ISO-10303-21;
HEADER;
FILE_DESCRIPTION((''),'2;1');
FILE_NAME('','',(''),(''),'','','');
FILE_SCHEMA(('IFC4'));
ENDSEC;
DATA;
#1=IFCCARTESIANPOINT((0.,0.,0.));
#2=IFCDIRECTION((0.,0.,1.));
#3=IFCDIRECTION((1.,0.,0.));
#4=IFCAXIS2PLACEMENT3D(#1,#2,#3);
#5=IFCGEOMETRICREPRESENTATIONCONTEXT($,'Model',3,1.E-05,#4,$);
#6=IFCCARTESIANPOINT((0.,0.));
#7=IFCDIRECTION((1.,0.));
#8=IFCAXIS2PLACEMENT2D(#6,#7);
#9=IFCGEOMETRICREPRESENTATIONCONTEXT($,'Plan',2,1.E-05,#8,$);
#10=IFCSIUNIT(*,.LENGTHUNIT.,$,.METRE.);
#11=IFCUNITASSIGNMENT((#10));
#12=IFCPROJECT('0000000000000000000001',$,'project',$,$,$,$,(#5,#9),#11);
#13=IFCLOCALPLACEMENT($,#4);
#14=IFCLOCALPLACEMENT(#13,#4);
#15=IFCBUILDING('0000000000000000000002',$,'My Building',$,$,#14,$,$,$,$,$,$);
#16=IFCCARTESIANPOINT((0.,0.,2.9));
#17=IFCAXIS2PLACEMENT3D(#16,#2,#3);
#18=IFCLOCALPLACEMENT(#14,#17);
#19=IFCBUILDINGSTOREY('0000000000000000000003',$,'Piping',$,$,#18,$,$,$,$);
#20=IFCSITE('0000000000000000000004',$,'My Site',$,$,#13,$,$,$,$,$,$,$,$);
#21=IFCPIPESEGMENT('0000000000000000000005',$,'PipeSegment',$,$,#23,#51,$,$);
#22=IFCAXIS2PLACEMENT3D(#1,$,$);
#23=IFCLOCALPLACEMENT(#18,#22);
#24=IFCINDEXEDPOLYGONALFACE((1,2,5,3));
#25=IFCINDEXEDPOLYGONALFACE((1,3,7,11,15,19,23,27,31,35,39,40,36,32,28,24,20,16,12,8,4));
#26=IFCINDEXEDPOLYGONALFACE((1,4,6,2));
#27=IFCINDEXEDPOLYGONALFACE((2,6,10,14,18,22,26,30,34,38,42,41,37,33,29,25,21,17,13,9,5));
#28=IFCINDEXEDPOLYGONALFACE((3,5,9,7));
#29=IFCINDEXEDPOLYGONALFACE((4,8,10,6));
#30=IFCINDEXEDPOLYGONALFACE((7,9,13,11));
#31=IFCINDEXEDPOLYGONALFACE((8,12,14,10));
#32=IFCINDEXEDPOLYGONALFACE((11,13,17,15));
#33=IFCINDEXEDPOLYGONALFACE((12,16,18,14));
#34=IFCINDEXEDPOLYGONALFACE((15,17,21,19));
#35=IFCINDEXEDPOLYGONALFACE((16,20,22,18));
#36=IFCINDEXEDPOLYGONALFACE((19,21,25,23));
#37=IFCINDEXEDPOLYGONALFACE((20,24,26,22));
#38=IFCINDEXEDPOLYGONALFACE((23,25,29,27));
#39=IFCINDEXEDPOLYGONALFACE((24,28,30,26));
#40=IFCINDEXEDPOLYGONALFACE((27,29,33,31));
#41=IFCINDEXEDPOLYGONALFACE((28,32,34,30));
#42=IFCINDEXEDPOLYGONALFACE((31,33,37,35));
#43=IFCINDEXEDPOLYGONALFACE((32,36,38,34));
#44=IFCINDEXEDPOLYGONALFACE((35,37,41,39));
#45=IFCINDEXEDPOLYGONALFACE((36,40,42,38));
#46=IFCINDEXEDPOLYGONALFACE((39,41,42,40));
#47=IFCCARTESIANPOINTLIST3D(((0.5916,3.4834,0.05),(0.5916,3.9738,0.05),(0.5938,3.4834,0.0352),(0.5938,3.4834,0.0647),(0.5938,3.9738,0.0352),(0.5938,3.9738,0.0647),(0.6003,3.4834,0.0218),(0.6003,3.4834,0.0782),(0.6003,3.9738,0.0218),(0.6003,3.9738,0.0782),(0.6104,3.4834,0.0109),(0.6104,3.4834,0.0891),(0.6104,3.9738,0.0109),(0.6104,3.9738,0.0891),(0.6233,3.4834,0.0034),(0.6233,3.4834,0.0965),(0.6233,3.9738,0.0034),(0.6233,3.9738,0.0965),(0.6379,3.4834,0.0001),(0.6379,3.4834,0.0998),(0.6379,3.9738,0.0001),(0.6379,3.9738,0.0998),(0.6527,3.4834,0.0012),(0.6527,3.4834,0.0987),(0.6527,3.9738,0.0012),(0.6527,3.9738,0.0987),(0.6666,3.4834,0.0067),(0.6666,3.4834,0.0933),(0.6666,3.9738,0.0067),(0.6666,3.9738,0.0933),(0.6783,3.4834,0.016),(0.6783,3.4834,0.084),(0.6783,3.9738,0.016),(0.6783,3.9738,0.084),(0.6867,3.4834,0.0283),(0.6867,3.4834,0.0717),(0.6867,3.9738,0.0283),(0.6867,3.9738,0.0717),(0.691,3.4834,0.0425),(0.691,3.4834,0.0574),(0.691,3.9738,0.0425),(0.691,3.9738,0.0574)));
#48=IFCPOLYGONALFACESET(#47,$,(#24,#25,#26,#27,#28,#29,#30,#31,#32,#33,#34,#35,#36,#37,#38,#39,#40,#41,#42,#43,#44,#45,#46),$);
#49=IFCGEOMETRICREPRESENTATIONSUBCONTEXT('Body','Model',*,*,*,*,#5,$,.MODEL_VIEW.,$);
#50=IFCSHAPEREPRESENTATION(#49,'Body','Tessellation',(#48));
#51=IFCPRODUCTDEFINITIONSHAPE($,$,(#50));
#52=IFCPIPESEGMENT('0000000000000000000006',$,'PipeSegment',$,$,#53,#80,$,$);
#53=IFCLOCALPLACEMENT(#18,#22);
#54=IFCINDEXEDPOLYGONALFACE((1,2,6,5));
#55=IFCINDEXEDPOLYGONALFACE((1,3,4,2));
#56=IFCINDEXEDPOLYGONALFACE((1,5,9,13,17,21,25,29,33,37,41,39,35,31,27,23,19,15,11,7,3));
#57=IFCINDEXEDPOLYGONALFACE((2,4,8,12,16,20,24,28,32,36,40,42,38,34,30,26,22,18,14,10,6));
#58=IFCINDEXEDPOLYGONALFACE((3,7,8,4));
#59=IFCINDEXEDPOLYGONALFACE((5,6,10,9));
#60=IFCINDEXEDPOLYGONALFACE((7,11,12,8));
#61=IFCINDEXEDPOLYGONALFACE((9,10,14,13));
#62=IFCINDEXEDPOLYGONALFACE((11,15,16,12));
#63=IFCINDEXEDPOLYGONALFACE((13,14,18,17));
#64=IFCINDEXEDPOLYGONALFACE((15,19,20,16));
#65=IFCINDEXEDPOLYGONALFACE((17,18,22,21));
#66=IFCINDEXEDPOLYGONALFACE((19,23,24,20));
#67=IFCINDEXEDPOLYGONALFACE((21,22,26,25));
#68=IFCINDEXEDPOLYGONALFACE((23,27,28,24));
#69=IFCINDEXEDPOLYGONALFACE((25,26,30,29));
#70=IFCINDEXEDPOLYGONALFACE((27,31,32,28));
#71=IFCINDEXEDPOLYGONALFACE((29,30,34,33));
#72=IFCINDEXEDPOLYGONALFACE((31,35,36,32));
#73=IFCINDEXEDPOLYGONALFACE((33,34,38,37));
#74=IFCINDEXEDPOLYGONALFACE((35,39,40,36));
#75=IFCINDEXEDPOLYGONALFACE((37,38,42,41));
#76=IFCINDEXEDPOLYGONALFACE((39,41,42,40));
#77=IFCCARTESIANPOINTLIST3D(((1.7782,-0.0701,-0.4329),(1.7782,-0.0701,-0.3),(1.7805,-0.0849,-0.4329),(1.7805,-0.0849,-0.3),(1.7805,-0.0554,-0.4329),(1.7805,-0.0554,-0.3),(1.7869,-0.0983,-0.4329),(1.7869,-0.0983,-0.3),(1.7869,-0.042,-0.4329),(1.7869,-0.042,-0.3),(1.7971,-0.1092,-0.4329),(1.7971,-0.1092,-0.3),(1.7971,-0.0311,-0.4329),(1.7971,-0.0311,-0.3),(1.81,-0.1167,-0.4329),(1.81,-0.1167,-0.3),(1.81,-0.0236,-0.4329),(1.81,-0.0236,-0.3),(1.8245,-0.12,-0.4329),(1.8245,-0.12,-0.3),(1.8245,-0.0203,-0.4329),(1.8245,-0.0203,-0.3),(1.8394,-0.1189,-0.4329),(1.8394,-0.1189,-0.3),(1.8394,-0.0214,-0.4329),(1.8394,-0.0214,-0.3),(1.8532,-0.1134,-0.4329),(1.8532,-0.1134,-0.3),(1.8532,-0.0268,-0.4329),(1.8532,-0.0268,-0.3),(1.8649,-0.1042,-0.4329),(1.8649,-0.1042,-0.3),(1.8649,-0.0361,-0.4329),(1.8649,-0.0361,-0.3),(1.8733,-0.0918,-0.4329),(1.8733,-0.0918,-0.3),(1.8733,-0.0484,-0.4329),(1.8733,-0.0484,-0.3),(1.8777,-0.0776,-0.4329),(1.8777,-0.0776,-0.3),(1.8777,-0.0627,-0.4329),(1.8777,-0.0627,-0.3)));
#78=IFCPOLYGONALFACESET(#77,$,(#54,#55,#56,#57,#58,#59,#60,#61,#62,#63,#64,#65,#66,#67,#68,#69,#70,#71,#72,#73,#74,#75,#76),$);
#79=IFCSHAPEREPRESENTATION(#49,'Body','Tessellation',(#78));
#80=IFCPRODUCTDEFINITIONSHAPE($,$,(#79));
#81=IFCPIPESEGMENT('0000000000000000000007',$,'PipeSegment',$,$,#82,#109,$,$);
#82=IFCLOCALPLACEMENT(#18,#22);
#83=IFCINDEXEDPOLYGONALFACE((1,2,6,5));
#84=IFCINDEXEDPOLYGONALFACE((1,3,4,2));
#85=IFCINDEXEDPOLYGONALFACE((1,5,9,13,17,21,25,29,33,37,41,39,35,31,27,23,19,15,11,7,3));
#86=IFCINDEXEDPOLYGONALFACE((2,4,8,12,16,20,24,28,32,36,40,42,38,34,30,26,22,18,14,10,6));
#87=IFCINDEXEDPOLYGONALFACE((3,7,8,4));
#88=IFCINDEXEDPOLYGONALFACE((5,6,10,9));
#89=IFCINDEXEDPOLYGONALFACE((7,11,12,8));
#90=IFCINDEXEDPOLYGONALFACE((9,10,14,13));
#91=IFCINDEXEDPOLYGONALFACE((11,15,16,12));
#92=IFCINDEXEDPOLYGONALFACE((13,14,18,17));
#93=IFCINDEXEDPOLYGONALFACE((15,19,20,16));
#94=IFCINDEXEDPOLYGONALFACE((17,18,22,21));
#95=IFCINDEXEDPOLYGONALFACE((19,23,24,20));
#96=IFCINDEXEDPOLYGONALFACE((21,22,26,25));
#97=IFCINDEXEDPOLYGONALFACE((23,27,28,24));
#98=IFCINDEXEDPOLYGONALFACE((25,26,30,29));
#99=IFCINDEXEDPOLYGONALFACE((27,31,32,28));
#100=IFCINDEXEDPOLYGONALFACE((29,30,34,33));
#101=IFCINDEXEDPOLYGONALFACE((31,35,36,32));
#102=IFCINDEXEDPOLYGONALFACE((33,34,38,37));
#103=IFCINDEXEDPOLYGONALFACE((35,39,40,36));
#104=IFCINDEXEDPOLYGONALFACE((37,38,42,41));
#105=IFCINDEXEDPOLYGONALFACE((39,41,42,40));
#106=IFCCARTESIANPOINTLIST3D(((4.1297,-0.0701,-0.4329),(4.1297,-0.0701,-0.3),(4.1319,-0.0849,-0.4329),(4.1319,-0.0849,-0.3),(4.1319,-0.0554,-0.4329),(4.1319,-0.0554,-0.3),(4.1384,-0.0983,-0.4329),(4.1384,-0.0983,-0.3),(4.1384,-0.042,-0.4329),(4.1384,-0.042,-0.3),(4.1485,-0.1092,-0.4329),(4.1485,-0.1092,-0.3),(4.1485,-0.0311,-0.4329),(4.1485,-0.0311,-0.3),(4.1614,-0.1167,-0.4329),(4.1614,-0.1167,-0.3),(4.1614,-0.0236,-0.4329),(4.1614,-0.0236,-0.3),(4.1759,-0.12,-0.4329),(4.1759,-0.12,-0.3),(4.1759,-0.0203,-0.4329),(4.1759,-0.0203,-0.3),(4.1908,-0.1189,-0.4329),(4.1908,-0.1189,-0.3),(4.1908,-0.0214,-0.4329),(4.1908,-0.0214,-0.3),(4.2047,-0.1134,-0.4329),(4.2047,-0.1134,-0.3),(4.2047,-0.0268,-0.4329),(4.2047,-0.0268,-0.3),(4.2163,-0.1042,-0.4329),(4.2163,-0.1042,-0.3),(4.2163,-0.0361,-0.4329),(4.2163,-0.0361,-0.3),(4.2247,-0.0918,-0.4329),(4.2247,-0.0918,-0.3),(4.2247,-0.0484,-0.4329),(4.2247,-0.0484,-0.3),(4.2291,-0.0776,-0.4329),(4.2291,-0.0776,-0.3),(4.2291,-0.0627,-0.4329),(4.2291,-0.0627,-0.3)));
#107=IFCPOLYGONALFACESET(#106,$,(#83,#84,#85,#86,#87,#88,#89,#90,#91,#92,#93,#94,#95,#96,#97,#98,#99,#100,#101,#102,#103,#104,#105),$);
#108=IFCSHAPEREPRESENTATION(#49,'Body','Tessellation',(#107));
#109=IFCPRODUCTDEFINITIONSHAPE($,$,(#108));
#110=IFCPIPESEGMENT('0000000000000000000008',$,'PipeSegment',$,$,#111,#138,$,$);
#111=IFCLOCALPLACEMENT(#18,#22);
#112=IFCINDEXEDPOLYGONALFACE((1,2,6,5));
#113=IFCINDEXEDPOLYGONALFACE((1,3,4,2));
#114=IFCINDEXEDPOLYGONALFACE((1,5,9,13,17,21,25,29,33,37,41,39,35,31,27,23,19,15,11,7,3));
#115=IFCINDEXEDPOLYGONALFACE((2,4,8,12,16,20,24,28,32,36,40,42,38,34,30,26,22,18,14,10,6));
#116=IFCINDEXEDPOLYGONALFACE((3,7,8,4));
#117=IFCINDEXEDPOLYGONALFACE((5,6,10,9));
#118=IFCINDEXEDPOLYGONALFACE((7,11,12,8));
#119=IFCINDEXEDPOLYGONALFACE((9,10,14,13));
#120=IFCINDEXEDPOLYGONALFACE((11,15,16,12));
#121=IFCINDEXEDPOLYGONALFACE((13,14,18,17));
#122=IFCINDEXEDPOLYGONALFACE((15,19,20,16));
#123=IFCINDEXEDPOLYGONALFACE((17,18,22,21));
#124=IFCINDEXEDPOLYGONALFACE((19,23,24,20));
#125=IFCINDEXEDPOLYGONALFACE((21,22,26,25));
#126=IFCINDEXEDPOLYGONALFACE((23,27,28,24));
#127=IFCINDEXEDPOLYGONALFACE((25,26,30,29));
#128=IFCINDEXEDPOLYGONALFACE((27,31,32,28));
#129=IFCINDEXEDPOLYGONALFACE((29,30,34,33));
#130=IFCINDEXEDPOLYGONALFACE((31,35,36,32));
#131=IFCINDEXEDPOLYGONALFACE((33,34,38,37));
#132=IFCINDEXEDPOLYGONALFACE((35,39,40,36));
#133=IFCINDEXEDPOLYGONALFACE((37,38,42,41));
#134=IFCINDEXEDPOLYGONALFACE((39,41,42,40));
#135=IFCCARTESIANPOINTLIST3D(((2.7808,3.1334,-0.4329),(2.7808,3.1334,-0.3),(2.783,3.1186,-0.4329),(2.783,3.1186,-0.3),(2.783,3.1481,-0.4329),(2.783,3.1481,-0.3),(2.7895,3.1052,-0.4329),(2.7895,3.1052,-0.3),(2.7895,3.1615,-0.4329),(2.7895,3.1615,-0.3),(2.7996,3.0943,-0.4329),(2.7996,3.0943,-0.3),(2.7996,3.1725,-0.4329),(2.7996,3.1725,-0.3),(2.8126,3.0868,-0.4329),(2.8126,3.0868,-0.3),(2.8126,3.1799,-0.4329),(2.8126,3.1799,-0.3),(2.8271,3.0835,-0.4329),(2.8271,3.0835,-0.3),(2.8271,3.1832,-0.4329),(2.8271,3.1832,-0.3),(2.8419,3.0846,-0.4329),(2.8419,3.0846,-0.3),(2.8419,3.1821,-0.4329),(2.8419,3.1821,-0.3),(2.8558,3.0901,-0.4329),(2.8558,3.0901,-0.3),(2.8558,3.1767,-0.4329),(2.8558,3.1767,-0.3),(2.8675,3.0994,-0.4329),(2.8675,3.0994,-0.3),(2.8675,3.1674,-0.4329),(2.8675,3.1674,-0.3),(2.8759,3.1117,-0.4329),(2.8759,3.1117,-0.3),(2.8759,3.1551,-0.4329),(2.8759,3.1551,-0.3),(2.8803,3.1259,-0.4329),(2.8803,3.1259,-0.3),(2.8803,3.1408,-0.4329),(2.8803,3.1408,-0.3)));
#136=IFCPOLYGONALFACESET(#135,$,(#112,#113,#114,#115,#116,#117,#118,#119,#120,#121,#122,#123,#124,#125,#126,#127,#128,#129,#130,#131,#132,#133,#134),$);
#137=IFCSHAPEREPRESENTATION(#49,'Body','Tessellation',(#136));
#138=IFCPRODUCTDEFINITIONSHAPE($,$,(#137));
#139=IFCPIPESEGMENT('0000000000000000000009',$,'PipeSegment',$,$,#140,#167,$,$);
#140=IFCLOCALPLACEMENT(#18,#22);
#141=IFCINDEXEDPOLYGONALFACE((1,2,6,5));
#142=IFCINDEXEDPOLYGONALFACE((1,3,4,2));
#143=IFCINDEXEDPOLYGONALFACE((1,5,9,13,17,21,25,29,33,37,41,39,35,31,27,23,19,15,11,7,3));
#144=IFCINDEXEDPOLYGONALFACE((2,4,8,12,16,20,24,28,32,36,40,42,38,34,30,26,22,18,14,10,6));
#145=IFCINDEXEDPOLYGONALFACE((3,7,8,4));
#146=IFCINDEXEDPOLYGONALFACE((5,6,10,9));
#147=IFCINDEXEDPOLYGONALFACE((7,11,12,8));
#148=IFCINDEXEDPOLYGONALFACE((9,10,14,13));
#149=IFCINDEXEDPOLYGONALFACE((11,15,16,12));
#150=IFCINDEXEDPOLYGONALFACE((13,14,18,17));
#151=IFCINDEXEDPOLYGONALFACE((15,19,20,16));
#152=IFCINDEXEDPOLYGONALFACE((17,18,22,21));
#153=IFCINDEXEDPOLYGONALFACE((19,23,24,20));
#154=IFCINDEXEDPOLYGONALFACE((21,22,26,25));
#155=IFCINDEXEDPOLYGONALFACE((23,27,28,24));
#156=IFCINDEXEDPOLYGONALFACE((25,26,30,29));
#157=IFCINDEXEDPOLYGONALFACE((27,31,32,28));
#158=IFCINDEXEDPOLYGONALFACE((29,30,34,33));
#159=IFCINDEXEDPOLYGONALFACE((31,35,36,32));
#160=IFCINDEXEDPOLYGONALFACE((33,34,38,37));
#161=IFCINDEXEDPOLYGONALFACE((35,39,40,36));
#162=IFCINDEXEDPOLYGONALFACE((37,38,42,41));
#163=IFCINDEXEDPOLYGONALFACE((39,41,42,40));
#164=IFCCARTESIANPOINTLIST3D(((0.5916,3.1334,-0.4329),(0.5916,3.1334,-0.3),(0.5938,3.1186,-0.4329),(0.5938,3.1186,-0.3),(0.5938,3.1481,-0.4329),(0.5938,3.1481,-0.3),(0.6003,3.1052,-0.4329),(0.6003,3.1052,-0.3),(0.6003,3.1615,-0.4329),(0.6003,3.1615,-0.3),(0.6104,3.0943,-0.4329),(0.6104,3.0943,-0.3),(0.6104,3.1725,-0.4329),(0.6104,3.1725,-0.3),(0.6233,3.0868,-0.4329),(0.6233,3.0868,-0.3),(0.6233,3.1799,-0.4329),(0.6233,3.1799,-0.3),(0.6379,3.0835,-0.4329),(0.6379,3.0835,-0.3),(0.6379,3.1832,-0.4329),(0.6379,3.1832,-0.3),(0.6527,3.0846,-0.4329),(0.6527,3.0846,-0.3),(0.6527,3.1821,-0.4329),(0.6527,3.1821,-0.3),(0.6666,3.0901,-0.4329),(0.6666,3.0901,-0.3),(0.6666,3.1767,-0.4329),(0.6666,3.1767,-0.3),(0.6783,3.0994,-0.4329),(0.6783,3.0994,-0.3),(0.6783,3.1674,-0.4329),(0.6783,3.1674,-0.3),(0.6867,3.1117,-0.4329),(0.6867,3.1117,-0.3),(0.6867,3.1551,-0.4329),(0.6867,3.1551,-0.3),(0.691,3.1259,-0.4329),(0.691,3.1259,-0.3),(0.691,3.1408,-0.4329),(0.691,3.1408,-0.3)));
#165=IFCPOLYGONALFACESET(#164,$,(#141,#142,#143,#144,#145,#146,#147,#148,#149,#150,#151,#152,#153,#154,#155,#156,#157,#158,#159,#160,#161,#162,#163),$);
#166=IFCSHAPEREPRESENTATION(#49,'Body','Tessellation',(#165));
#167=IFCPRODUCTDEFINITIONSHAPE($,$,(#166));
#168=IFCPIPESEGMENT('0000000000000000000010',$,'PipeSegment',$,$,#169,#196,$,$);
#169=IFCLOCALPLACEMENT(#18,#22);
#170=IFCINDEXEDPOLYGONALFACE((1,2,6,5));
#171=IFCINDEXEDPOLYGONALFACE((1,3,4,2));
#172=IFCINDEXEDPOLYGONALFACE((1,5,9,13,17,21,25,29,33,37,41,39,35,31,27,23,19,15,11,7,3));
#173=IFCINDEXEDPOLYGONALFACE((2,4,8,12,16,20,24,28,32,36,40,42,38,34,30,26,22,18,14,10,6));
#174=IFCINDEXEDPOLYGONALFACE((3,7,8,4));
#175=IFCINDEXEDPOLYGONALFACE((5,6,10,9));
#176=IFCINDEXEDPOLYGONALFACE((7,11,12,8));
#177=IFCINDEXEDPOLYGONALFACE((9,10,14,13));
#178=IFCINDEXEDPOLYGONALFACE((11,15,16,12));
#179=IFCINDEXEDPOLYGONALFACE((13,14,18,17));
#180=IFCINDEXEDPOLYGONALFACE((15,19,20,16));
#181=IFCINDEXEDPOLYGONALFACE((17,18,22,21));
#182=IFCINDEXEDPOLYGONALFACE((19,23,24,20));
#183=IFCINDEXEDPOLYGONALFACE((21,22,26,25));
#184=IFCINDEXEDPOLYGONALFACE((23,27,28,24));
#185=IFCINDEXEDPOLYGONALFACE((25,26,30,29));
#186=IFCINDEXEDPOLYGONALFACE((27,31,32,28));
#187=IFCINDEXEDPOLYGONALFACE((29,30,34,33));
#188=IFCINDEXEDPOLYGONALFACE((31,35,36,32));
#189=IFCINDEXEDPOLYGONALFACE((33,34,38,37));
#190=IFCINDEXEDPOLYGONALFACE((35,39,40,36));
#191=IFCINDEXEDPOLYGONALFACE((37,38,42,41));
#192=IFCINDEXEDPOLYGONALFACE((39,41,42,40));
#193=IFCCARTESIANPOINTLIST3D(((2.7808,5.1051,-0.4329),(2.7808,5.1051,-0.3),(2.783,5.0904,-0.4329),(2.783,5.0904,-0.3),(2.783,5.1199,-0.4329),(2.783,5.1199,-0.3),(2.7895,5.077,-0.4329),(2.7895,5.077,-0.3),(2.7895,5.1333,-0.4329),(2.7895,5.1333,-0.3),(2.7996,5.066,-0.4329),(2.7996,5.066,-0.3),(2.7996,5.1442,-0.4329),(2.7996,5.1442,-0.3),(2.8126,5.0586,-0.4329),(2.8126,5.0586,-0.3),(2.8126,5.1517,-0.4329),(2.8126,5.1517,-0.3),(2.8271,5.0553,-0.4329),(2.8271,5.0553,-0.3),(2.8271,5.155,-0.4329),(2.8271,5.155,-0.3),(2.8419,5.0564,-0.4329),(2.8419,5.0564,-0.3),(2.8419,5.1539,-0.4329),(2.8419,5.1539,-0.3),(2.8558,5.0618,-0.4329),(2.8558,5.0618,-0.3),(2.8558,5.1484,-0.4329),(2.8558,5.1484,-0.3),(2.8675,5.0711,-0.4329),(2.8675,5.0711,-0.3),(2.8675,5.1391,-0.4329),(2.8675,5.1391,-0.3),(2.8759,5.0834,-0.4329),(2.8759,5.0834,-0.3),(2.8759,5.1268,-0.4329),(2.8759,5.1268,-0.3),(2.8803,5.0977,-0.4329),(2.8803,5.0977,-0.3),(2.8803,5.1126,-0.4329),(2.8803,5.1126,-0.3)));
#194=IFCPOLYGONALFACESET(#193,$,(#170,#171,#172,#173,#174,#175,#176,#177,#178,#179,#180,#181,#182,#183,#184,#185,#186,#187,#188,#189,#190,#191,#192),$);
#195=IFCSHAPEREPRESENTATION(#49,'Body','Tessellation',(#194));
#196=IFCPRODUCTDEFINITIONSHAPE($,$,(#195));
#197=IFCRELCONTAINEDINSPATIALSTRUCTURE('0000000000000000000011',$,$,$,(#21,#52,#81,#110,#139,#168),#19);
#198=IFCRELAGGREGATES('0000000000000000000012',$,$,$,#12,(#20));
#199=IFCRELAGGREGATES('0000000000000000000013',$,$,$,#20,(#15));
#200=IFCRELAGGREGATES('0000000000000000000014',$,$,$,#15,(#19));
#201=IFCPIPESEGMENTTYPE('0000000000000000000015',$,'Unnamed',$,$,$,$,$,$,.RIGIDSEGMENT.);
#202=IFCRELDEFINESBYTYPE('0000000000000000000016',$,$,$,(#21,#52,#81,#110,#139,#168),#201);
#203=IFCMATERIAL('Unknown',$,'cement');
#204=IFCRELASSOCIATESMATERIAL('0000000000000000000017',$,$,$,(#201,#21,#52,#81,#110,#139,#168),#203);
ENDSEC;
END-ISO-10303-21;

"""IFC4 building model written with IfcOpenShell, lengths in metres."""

from ifc_helpers import new_model, si_unit, frame, origin_with_axes, origin_2d_with_axis, place, context, subcontext, project, spatial, circle, extrude, material, material_profile, profile_set, profile_usage, type_object, element, save


model = new_model("IFC4")

# Units and contexts
model_context = context("Model", 3, precision=1e-05, world=origin_with_axes())
plan_context = context("Plan", 2, precision=1e-05, world=origin_2d_with_axis())
body_context = subcontext(model_context, "Body", "Model", "MODEL_VIEW")
ifc_project = project(units=[si_unit("LENGTHUNIT", "METRE")], contexts=[model_context, plan_context])

# Site, building, storey
site_placement = place(None, origin_with_axes())
site = spatial("IfcSite", under=ifc_project, at=site_placement, Name="My Site")
building_placement = place(site_placement, origin_with_axes())
building = spatial("IfcBuilding", under=site, at=building_placement, Name="My Building")
storey_placement = place(building_placement, frame((0.0, 0.0, 2.9), z_axis=(0.0, 0.0, 1.0), x_axis=(1.0, 0.0, 0.0)))
storey = spatial("IfcBuildingStorey", under=building, at=storey_placement, Name="Piping")

# Pipe segments
ifc_material = material(Name="Unknown", Category="cement")
ifc_material_profile_1 = material_profile(ifc_material, circle(Radius=0.05))
ifc_profile_set_1 = profile_set([ifc_material_profile_1])
pipe_segment_type = type_object("IfcPipeSegmentType", Name="Unnamed", PredefinedType="RIGIDSEGMENT", material=ifc_profile_set_1)
ifc_profile_usage_1 = profile_usage(ifc_profile_set_1, cardinal=5)
pipe_segment_1_placement = place(storey_placement, frame((0.6416, 3.4834, 0.05), z_axis=(0.0, 1.0, 0.0), x_axis=(-1.0, 0.0, 0.0)))
element("IfcPipeSegment", 1, at=pipe_segment_1_placement, inside=storey, type_object=pipe_segment_type, material=ifc_profile_usage_1, Name="PipeSegment", context=body_context, shape_type="SweptSolid", body=[
    extrude(circle(Radius=0.05), origin_with_axes(), (0.0, 0.0, 1.0), 0.4905),
])
ifc_profile_usage_2 = profile_usage(ifc_profile_set_1, cardinal=5)
pipe_segment_2_placement = place(storey_placement, frame((1.8282, -0.0701, -0.4329), z_axis=(0.0, 0.0, 1.0), x_axis=(-1.0, 0.0, 0.0)))
element("IfcPipeSegment", 2, at=pipe_segment_2_placement, inside=storey, type_object=pipe_segment_type, material=ifc_profile_usage_2, Name="PipeSegment", context=body_context, shape_type="SweptSolid", body=[
    extrude(circle(Radius=0.05), origin_with_axes(), (0.0, 0.0, 1.0), 0.1329),
])
ifc_profile_usage_3 = profile_usage(ifc_profile_set_1, cardinal=5)
pipe_segment_3_placement = place(storey_placement, frame((4.1797, -0.0701, -0.4329), z_axis=(0.0, 0.0, 1.0), x_axis=(-1.0, 0.0, 0.0)))
element("IfcPipeSegment", 3, at=pipe_segment_3_placement, inside=storey, type_object=pipe_segment_type, material=ifc_profile_usage_3, Name="PipeSegment", context=body_context, shape_type="SweptSolid", body=[
    extrude(circle(Radius=0.05), origin_with_axes(), (0.0, 0.0, 1.0), 0.1329),
])
ifc_profile_usage_4 = profile_usage(ifc_profile_set_1, cardinal=5)
pipe_segment_4_placement = place(storey_placement, frame((2.8308, 3.1334, -0.4329), z_axis=(0.0, 0.0, 1.0), x_axis=(-1.0, 0.0, 0.0)))
element("IfcPipeSegment", 4, at=pipe_segment_4_placement, inside=storey, type_object=pipe_segment_type, material=ifc_profile_usage_4, Name="PipeSegment", context=body_context, shape_type="SweptSolid", body=[
    extrude(circle(Radius=0.05), origin_with_axes(), (0.0, 0.0, 1.0), 0.1329),
])
ifc_profile_usage_5 = profile_usage(ifc_profile_set_1, cardinal=5)
pipe_segment_5_placement = place(storey_placement, frame((0.6416, 3.1334, -0.4329), z_axis=(0.0, 0.0, 1.0), x_axis=(-1.0, 0.0, 0.0)))
element("IfcPipeSegment", 5, at=pipe_segment_5_placement, inside=storey, type_object=pipe_segment_type, material=ifc_profile_usage_5, Name="PipeSegment", context=body_context, shape_type="SweptSolid", body=[
    extrude(circle(Radius=0.05), origin_with_axes(), (0.0, 0.0, 1.0), 0.1329),
])
ifc_profile_usage_6 = profile_usage(ifc_profile_set_1, cardinal=5)
pipe_segment_6_placement = place(storey_placement, frame((2.8308, 5.1051, -0.4329), z_axis=(0.0, 0.0, 1.0), x_axis=(-1.0, 0.0, 0.0)))
element("IfcPipeSegment", 6, at=pipe_segment_6_placement, inside=storey, type_object=pipe_segment_type, material=ifc_profile_usage_6, Name="PipeSegment", context=body_context, shape_type="SweptSolid", body=[
    extrude(circle(Radius=0.05), origin_with_axes(), (0.0, 0.0, 1.0), 0.1329),
])

save(model, "model.ifc")
